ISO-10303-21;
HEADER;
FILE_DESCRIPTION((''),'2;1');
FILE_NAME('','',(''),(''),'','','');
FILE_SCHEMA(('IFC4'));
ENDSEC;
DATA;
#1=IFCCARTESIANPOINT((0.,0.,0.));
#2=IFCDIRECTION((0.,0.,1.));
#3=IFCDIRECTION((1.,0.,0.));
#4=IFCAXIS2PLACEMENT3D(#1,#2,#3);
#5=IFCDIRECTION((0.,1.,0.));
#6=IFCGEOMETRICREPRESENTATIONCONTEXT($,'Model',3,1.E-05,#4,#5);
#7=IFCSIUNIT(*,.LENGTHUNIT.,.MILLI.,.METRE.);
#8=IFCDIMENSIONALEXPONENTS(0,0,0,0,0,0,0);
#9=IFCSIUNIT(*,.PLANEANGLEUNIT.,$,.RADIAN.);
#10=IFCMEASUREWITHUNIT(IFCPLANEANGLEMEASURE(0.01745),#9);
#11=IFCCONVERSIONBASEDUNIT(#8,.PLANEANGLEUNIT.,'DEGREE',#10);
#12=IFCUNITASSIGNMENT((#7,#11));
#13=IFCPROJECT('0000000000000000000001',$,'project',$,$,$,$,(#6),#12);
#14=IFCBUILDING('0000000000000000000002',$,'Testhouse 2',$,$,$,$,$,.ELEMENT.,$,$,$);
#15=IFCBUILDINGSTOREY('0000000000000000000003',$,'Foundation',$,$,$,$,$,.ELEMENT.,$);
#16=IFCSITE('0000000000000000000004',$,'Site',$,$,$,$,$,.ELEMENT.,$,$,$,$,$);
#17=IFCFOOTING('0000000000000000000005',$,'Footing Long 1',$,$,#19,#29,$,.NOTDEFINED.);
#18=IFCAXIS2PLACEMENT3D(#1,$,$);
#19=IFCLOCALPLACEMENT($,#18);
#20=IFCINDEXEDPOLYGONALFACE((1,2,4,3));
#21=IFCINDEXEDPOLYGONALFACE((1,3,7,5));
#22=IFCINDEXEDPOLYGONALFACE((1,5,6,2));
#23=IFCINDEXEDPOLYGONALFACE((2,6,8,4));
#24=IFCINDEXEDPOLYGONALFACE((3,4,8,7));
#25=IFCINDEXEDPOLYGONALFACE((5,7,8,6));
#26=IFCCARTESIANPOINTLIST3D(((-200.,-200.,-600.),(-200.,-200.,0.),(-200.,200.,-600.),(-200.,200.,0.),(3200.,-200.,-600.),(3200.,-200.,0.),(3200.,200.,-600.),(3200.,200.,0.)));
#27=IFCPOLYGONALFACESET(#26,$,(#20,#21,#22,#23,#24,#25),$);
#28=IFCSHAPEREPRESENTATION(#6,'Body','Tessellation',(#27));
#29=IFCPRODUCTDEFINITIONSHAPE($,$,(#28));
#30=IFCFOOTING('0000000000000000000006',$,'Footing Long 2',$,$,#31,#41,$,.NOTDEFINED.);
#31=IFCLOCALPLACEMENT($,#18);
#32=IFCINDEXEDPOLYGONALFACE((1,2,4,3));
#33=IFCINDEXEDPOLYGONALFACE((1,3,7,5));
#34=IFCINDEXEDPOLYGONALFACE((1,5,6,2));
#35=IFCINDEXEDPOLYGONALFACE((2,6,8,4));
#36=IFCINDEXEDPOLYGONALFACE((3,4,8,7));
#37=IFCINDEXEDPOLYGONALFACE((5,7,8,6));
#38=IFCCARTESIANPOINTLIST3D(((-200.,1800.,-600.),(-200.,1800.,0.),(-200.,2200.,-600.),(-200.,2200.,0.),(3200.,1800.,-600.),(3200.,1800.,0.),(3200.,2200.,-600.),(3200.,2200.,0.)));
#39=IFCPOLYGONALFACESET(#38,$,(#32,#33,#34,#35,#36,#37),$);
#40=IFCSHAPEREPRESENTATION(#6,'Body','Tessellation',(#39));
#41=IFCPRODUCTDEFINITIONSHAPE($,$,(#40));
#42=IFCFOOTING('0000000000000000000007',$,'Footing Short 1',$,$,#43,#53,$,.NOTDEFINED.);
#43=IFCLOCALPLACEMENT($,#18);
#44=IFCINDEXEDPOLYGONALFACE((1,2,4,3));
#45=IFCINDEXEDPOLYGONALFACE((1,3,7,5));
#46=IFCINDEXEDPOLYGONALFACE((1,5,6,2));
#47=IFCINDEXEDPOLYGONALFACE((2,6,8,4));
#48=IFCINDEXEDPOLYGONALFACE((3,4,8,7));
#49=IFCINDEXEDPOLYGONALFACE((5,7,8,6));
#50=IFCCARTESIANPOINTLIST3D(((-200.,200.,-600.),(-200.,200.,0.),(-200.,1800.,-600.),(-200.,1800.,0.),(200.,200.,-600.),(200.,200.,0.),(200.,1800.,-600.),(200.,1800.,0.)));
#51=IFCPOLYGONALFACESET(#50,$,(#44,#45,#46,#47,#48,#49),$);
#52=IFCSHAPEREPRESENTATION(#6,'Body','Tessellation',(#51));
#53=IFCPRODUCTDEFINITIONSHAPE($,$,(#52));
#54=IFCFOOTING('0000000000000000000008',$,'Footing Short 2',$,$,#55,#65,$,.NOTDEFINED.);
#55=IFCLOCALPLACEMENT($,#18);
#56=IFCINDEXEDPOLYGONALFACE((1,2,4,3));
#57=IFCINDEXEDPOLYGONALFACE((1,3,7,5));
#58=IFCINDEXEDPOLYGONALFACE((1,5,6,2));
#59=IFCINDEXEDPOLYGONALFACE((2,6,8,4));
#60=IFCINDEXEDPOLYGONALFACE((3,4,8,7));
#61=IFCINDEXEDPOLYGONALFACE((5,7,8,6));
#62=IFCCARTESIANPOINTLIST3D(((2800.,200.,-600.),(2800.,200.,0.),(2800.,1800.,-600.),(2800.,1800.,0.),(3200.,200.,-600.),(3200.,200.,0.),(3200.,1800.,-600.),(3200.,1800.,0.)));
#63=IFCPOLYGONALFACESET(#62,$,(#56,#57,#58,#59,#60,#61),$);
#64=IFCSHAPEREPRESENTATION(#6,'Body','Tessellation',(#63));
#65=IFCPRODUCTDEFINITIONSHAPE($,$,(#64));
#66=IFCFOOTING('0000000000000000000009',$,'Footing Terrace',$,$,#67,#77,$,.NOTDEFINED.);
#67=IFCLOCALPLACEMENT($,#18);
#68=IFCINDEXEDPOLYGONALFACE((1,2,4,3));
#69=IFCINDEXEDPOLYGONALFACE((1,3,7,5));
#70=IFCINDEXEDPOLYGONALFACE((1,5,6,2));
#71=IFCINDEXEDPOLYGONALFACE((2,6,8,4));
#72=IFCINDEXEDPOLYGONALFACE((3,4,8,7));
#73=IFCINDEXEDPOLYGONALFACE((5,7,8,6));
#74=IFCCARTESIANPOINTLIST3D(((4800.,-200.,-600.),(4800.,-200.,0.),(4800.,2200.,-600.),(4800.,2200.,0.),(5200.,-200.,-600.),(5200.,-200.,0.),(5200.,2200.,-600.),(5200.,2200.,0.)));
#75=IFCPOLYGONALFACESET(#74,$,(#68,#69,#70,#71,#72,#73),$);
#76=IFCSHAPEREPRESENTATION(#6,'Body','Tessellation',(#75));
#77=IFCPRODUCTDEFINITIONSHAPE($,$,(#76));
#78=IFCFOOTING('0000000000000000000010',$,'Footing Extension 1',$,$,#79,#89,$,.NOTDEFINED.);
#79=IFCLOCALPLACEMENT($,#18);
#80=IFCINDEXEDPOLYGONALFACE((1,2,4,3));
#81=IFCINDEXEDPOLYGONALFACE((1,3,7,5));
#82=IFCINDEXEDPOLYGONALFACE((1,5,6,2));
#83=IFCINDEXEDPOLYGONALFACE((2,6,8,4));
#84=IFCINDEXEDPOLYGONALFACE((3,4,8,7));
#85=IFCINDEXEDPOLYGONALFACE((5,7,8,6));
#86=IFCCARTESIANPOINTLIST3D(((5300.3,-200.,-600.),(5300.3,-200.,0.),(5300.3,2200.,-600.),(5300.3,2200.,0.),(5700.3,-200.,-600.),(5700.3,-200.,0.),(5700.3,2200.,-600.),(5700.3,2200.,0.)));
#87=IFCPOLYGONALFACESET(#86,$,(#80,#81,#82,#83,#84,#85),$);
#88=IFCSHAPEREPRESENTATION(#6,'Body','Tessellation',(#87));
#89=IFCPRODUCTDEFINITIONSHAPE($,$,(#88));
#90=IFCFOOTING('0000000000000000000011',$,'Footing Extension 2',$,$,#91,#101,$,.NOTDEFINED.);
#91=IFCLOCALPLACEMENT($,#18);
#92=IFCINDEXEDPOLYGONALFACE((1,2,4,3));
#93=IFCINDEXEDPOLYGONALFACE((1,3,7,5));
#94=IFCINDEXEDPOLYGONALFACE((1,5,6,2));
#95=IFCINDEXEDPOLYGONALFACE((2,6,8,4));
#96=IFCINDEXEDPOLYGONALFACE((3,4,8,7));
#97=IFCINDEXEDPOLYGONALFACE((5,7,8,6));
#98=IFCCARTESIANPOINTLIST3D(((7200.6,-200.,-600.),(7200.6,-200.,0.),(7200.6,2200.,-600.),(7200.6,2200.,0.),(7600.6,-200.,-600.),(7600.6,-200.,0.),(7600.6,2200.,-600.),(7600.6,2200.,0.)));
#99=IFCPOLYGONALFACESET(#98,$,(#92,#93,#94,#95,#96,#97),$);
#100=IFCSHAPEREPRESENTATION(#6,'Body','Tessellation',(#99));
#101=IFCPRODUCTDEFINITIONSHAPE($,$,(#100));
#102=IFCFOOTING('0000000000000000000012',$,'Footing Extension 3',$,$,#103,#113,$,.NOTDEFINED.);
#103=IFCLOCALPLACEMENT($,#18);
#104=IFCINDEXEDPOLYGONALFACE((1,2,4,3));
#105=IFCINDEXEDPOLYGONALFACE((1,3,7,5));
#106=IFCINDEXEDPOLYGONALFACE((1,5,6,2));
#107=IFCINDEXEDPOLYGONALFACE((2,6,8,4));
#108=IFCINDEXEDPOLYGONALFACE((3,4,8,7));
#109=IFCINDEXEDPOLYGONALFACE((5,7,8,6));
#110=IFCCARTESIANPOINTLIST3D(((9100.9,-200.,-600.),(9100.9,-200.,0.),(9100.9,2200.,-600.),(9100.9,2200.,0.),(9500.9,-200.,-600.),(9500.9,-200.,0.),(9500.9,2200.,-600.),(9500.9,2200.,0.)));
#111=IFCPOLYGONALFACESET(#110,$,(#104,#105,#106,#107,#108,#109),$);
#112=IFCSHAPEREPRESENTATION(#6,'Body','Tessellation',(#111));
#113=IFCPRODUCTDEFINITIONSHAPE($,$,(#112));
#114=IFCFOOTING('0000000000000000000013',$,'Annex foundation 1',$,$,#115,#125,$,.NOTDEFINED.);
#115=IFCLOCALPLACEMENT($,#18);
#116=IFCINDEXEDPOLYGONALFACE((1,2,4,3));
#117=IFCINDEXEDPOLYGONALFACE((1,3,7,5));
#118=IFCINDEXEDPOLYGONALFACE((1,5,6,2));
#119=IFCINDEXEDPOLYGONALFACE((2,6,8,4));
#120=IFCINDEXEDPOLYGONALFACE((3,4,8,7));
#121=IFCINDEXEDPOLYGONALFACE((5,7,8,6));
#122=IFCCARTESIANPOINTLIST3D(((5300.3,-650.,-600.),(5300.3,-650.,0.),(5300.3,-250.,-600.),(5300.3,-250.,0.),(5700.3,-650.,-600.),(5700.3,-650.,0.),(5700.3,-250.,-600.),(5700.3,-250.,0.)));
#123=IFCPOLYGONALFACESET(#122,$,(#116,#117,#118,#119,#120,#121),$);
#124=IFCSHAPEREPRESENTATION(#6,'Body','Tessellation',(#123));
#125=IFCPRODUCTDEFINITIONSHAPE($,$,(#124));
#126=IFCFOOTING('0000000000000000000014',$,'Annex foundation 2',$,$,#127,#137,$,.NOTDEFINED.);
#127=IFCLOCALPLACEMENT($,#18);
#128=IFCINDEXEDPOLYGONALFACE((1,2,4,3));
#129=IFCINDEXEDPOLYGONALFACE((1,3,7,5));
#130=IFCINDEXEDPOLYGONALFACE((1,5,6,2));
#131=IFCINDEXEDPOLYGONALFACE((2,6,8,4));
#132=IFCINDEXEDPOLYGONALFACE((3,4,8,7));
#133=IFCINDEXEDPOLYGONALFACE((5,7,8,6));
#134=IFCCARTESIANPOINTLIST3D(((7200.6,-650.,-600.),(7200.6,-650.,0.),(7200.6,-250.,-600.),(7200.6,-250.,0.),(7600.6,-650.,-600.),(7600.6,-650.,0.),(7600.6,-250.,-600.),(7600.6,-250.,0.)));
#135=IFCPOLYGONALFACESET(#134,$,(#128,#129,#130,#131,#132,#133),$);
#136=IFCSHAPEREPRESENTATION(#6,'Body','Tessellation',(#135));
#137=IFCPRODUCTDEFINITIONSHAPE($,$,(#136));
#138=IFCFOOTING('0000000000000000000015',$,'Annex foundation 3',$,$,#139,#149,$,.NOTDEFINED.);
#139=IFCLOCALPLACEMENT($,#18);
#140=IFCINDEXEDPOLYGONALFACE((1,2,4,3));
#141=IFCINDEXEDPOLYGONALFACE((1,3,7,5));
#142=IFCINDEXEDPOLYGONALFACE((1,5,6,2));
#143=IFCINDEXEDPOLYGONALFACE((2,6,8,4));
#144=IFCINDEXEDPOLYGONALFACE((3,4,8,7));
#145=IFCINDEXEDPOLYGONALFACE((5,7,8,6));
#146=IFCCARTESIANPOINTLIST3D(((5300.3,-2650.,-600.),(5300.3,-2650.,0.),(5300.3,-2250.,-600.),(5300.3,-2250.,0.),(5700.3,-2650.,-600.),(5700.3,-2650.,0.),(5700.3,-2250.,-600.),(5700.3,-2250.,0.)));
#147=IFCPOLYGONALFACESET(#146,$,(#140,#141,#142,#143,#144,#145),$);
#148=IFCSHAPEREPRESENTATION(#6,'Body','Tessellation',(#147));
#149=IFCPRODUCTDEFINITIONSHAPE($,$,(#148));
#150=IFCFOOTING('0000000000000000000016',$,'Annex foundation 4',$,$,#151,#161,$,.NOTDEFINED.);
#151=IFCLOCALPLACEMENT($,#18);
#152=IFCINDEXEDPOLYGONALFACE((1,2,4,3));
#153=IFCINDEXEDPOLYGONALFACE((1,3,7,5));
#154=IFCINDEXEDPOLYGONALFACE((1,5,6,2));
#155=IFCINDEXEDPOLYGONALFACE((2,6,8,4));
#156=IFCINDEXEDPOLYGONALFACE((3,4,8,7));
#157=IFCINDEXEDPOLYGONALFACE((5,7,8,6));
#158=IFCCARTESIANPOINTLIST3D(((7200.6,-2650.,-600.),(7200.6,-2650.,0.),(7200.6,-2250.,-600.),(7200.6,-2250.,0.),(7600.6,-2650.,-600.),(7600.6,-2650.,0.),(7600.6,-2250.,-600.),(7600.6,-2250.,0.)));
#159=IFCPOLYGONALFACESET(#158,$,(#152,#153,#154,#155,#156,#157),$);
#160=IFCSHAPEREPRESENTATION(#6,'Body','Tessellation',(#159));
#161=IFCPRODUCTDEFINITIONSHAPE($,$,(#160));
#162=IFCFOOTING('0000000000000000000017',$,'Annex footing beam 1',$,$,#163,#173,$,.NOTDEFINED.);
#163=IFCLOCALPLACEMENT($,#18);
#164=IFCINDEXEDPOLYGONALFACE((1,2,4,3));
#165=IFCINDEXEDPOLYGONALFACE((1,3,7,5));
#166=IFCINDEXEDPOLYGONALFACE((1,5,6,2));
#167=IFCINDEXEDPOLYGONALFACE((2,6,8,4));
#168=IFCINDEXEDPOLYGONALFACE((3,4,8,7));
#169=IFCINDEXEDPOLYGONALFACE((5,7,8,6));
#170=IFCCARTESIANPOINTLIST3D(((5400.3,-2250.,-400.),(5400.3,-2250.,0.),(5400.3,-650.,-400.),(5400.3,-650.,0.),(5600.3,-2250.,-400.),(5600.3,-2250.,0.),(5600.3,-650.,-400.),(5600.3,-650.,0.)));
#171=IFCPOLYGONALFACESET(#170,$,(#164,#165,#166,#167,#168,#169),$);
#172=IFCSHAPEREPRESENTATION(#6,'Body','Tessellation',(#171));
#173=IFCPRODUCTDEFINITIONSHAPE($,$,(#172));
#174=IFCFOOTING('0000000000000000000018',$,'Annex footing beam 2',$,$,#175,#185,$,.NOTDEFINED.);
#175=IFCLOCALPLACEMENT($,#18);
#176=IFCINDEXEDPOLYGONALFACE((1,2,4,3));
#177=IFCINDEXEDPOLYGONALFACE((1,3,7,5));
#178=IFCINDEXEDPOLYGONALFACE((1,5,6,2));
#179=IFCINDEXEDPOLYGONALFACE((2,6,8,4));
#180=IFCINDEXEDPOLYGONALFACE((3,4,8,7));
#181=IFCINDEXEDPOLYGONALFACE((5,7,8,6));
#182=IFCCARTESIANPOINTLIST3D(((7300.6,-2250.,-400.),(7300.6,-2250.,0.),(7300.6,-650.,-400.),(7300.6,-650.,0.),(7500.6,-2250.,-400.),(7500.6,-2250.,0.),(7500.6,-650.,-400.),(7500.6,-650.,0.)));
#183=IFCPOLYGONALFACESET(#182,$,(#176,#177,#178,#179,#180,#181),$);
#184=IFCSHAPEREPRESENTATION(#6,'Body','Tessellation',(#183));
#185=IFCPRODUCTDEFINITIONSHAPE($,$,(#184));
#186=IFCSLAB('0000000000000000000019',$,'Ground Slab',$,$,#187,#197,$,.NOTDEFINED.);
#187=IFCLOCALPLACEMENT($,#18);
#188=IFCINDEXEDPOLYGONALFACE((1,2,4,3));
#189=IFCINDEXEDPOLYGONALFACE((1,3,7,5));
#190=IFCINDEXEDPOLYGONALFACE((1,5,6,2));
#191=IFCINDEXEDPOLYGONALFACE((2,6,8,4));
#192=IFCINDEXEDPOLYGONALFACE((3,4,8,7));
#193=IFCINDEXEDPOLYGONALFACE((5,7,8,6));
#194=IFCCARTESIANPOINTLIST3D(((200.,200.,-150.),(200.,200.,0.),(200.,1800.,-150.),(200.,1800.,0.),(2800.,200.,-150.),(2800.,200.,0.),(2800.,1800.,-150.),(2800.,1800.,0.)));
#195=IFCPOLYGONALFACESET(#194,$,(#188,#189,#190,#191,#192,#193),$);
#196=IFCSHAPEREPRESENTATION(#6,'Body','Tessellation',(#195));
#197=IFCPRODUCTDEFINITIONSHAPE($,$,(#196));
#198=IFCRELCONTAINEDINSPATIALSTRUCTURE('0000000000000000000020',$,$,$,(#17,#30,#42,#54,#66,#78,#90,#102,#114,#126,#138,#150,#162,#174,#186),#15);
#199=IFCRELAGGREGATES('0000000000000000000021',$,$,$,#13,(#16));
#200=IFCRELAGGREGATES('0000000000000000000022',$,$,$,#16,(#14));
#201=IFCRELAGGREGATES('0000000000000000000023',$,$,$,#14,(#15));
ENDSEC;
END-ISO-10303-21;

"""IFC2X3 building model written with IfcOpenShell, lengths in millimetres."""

from ifc_helpers import new_model, entity, si_unit, converted_unit, direction, frame, origin_with_axes, place, context, project, spatial, polyline, outline, extrude, element, save


model = new_model("IFC2X3")

# Units and contexts
model_context = context("Model", 3, precision=1e-05, world=origin_with_axes(), true_north=direction((0.0, 1.0, 0.0)))
ifc_project = project(units=[si_unit("LENGTHUNIT", "METRE", prefix="MILLI"), converted_unit("PLANEANGLEUNIT", "DEGREE", entity("IfcPlaneAngleMeasure", 0.01745), si_unit("PLANEANGLEUNIT", "RADIAN"), dimensions=[0, 0, 0, 0, 0, 0, 0])], contexts=[model_context])

# Site, building, storey
site = spatial("IfcSite", under=ifc_project, Name="Site", CompositionType="ELEMENT")
building = spatial("IfcBuilding", under=site, Name="Testhouse 2", CompositionType="ELEMENT")
storey = spatial("IfcBuildingStorey", under=building, Name="Foundation", CompositionType="ELEMENT")

# Footings
footing_1_placement = place(None, origin_with_axes())
element("IfcFooting", 1, at=footing_1_placement, inside=storey, Name="Footing Long 1", PredefinedType="NOTDEFINED", context=model_context, shape_type="SweptSolid", body=[
    extrude(outline(polyline([(-300.0, -200.0), (300.0, -200.0), (300.0, 200.0), (-300.0, 200.0), (-300.0, -200.0)])), frame((-200.0, 0.0, -300.0), z_axis=(1.0, 0.0, 0.0), x_axis=(0.0, 0.0, -1.0)), (0.0, 0.0, 1.0), 3400.0),
])
footing_2_placement = place(None, origin_with_axes())
element("IfcFooting", 2, at=footing_2_placement, inside=storey, Name="Footing Long 2", PredefinedType="NOTDEFINED", context=model_context, shape_type="SweptSolid", body=[
    extrude(outline(polyline([(-300.0, -200.0), (300.0, -200.0), (300.0, 200.0), (-300.0, 200.0), (-300.0, -200.0)])), frame((-200.0, 2000.0, -300.0), z_axis=(1.0, 0.0, 0.0), x_axis=(0.0, 0.0, -1.0)), (0.0, 0.0, 1.0), 3400.0),
])
footing_3_placement = place(None, origin_with_axes())
element("IfcFooting", 3, at=footing_3_placement, inside=storey, Name="Footing Short 1", PredefinedType="NOTDEFINED", context=model_context, shape_type="SweptSolid", body=[
    extrude(outline(polyline([(-300.0, -200.0), (300.0, -200.0), (300.0, 200.0), (-300.0, 200.0), (-300.0, -200.0)])), frame((0.0, 200.0, -300.0), z_axis=(0.0, 1.0, 0.0), x_axis=(0.0, 0.0, -1.0)), (0.0, 0.0, 1.0), 1600.0),
])
footing_4_placement = place(None, origin_with_axes())
element("IfcFooting", 4, at=footing_4_placement, inside=storey, Name="Footing Short 2", PredefinedType="NOTDEFINED", context=model_context, shape_type="SweptSolid", body=[
    extrude(outline(polyline([(-300.0, -200.0), (300.0, -200.0), (300.0, 200.0), (-300.0, 200.0), (-300.0, -200.0)])), frame((3000.0, 200.0, -300.0), z_axis=(0.0, 1.0, 0.0), x_axis=(0.0, 0.0, -1.0)), (0.0, 0.0, 1.0), 1600.0),
])
footing_5_placement = place(None, origin_with_axes())
element("IfcFooting", 5, at=footing_5_placement, inside=storey, Name="Footing Terrace", PredefinedType="NOTDEFINED", context=model_context, shape_type="SweptSolid", body=[
    extrude(outline(polyline([(-300.0, -200.0), (300.0, -200.0), (300.0, 200.0), (-300.0, 200.0), (-300.0, -200.0)])), frame((5000.0, -200.0, -300.0), z_axis=(0.0, 1.0, 0.0), x_axis=(0.0, 0.0, -1.0)), (0.0, 0.0, 1.0), 2400.0),
])
footing_6_placement = place(None, origin_with_axes())
element("IfcFooting", 6, at=footing_6_placement, inside=storey, Name="Footing Extension 1", PredefinedType="NOTDEFINED", context=model_context, shape_type="SweptSolid", body=[
    extrude(outline(polyline([(-300.0, -200.0), (300.0, -200.0), (300.0, 200.0), (-300.0, 200.0), (-300.0, -200.0)])), frame((5500.3, -200.0, -300.0), z_axis=(0.0, 1.0, 0.0), x_axis=(0.0, 0.0, -1.0)), (0.0, 0.0, 1.0), 2400.0),
])
footing_7_placement = place(None, origin_with_axes())
element("IfcFooting", 7, at=footing_7_placement, inside=storey, Name="Footing Extension 2", PredefinedType="NOTDEFINED", context=model_context, shape_type="SweptSolid", body=[
    extrude(outline(polyline([(-300.0, -200.0), (300.0, -200.0), (300.0, 200.0), (-300.0, 200.0), (-300.0, -200.0)])), frame((7400.6, -200.0, -300.0), z_axis=(0.0, 1.0, 0.0), x_axis=(0.0, 0.0, -1.0)), (0.0, 0.0, 1.0), 2400.0),
])
footing_8_placement = place(None, origin_with_axes())
element("IfcFooting", 8, at=footing_8_placement, inside=storey, Name="Footing Extension 3", PredefinedType="NOTDEFINED", context=model_context, shape_type="SweptSolid", body=[
    extrude(outline(polyline([(-300.0, -200.0), (300.0, -200.0), (300.0, 200.0), (-300.0, 200.0), (-300.0, -200.0)])), frame((9300.9, -200.0, -300.0), z_axis=(0.0, 1.0, 0.0), x_axis=(0.0, 0.0, -1.0)), (0.0, 0.0, 1.0), 2400.0),
])
footing_9_placement = place(None, origin_with_axes())
element("IfcFooting", 9, at=footing_9_placement, inside=storey, Name="Annex foundation 1", PredefinedType="NOTDEFINED", context=model_context, shape_type="SweptSolid", body=[
    extrude(outline(polyline([(-200.0, -200.0), (200.0, -200.0), (200.0, 200.0), (-200.0, 200.0), (-200.0, -200.0)])), frame((5500.3, -450.0, -600.0), z_axis=(0.0, 0.0, 1.0), x_axis=(1.0, 0.0, 0.0)), (0.0, 0.0, 1.0), 600.0),
])
footing_10_placement = place(None, origin_with_axes())
element("IfcFooting", 10, at=footing_10_placement, inside=storey, Name="Annex foundation 2", PredefinedType="NOTDEFINED", context=model_context, shape_type="SweptSolid", body=[
    extrude(outline(polyline([(-200.0, -200.0), (200.0, -200.0), (200.0, 200.0), (-200.0, 200.0), (-200.0, -200.0)])), frame((7400.6, -450.0, -600.0), z_axis=(0.0, 0.0, 1.0), x_axis=(1.0, 0.0, 0.0)), (0.0, 0.0, 1.0), 600.0),
])
footing_11_placement = place(None, origin_with_axes())
element("IfcFooting", 11, at=footing_11_placement, inside=storey, Name="Annex foundation 3", PredefinedType="NOTDEFINED", context=model_context, shape_type="SweptSolid", body=[
    extrude(outline(polyline([(-200.0, -200.0), (200.0, -200.0), (200.0, 200.0), (-200.0, 200.0), (-200.0, -200.0)])), frame((5500.3, -2450.0, -600.0), z_axis=(0.0, 0.0, 1.0), x_axis=(1.0, 0.0, 0.0)), (0.0, 0.0, 1.0), 600.0),
])
footing_12_placement = place(None, origin_with_axes())
element("IfcFooting", 12, at=footing_12_placement, inside=storey, Name="Annex foundation 4", PredefinedType="NOTDEFINED", context=model_context, shape_type="SweptSolid", body=[
    extrude(outline(polyline([(-200.0, -200.0), (200.0, -200.0), (200.0, 200.0), (-200.0, 200.0), (-200.0, -200.0)])), frame((7400.6, -2450.0, -600.0), z_axis=(0.0, 0.0, 1.0), x_axis=(1.0, 0.0, 0.0)), (0.0, 0.0, 1.0), 600.0),
])
footing_13_placement = place(None, origin_with_axes())
element("IfcFooting", 13, at=footing_13_placement, inside=storey, Name="Annex footing beam 1", PredefinedType="NOTDEFINED", context=model_context, shape_type="SweptSolid", body=[
    extrude(outline(polyline([(-200.0, -100.0), (200.0, -100.0), (200.0, 100.0), (-200.0, 100.0), (-200.0, -100.0)])), frame((5500.3, -2250.0, -200.0), z_axis=(0.0, 1.0, 0.0), x_axis=(0.0, 0.0, -1.0)), (0.0, 0.0, 1.0), 1600.0),
])
footing_14_placement = place(None, origin_with_axes())
element("IfcFooting", 14, at=footing_14_placement, inside=storey, Name="Annex footing beam 2", PredefinedType="NOTDEFINED", context=model_context, shape_type="SweptSolid", body=[
    extrude(outline(polyline([(-200.0, -100.0), (200.0, -100.0), (200.0, 100.0), (-200.0, 100.0), (-200.0, -100.0)])), frame((7400.6, -2250.0, -200.0), z_axis=(0.0, 1.0, 0.0), x_axis=(0.0, 0.0, -1.0)), (0.0, 0.0, 1.0), 1600.0),
])

# Slab
slab_1_placement = place(None, origin_with_axes())
element("IfcSlab", 15, at=slab_1_placement, inside=storey, Name="Ground Slab", PredefinedType="NOTDEFINED", context=model_context, shape_type="SweptSolid", body=[
    extrude(outline(polyline([(0.0, 0.0), (2600.0, 0.0), (2600.0, -1600.0), (0.0, -1600.0), (0.0, 0.0)])), frame((200.0, 1800.0, -150.0), z_axis=(0.0, 0.0, 1.0), x_axis=(1.0, 0.0, 0.0)), (0.0, 0.0, 1.0), 150.0),
])

save(model, "model.ifc")
